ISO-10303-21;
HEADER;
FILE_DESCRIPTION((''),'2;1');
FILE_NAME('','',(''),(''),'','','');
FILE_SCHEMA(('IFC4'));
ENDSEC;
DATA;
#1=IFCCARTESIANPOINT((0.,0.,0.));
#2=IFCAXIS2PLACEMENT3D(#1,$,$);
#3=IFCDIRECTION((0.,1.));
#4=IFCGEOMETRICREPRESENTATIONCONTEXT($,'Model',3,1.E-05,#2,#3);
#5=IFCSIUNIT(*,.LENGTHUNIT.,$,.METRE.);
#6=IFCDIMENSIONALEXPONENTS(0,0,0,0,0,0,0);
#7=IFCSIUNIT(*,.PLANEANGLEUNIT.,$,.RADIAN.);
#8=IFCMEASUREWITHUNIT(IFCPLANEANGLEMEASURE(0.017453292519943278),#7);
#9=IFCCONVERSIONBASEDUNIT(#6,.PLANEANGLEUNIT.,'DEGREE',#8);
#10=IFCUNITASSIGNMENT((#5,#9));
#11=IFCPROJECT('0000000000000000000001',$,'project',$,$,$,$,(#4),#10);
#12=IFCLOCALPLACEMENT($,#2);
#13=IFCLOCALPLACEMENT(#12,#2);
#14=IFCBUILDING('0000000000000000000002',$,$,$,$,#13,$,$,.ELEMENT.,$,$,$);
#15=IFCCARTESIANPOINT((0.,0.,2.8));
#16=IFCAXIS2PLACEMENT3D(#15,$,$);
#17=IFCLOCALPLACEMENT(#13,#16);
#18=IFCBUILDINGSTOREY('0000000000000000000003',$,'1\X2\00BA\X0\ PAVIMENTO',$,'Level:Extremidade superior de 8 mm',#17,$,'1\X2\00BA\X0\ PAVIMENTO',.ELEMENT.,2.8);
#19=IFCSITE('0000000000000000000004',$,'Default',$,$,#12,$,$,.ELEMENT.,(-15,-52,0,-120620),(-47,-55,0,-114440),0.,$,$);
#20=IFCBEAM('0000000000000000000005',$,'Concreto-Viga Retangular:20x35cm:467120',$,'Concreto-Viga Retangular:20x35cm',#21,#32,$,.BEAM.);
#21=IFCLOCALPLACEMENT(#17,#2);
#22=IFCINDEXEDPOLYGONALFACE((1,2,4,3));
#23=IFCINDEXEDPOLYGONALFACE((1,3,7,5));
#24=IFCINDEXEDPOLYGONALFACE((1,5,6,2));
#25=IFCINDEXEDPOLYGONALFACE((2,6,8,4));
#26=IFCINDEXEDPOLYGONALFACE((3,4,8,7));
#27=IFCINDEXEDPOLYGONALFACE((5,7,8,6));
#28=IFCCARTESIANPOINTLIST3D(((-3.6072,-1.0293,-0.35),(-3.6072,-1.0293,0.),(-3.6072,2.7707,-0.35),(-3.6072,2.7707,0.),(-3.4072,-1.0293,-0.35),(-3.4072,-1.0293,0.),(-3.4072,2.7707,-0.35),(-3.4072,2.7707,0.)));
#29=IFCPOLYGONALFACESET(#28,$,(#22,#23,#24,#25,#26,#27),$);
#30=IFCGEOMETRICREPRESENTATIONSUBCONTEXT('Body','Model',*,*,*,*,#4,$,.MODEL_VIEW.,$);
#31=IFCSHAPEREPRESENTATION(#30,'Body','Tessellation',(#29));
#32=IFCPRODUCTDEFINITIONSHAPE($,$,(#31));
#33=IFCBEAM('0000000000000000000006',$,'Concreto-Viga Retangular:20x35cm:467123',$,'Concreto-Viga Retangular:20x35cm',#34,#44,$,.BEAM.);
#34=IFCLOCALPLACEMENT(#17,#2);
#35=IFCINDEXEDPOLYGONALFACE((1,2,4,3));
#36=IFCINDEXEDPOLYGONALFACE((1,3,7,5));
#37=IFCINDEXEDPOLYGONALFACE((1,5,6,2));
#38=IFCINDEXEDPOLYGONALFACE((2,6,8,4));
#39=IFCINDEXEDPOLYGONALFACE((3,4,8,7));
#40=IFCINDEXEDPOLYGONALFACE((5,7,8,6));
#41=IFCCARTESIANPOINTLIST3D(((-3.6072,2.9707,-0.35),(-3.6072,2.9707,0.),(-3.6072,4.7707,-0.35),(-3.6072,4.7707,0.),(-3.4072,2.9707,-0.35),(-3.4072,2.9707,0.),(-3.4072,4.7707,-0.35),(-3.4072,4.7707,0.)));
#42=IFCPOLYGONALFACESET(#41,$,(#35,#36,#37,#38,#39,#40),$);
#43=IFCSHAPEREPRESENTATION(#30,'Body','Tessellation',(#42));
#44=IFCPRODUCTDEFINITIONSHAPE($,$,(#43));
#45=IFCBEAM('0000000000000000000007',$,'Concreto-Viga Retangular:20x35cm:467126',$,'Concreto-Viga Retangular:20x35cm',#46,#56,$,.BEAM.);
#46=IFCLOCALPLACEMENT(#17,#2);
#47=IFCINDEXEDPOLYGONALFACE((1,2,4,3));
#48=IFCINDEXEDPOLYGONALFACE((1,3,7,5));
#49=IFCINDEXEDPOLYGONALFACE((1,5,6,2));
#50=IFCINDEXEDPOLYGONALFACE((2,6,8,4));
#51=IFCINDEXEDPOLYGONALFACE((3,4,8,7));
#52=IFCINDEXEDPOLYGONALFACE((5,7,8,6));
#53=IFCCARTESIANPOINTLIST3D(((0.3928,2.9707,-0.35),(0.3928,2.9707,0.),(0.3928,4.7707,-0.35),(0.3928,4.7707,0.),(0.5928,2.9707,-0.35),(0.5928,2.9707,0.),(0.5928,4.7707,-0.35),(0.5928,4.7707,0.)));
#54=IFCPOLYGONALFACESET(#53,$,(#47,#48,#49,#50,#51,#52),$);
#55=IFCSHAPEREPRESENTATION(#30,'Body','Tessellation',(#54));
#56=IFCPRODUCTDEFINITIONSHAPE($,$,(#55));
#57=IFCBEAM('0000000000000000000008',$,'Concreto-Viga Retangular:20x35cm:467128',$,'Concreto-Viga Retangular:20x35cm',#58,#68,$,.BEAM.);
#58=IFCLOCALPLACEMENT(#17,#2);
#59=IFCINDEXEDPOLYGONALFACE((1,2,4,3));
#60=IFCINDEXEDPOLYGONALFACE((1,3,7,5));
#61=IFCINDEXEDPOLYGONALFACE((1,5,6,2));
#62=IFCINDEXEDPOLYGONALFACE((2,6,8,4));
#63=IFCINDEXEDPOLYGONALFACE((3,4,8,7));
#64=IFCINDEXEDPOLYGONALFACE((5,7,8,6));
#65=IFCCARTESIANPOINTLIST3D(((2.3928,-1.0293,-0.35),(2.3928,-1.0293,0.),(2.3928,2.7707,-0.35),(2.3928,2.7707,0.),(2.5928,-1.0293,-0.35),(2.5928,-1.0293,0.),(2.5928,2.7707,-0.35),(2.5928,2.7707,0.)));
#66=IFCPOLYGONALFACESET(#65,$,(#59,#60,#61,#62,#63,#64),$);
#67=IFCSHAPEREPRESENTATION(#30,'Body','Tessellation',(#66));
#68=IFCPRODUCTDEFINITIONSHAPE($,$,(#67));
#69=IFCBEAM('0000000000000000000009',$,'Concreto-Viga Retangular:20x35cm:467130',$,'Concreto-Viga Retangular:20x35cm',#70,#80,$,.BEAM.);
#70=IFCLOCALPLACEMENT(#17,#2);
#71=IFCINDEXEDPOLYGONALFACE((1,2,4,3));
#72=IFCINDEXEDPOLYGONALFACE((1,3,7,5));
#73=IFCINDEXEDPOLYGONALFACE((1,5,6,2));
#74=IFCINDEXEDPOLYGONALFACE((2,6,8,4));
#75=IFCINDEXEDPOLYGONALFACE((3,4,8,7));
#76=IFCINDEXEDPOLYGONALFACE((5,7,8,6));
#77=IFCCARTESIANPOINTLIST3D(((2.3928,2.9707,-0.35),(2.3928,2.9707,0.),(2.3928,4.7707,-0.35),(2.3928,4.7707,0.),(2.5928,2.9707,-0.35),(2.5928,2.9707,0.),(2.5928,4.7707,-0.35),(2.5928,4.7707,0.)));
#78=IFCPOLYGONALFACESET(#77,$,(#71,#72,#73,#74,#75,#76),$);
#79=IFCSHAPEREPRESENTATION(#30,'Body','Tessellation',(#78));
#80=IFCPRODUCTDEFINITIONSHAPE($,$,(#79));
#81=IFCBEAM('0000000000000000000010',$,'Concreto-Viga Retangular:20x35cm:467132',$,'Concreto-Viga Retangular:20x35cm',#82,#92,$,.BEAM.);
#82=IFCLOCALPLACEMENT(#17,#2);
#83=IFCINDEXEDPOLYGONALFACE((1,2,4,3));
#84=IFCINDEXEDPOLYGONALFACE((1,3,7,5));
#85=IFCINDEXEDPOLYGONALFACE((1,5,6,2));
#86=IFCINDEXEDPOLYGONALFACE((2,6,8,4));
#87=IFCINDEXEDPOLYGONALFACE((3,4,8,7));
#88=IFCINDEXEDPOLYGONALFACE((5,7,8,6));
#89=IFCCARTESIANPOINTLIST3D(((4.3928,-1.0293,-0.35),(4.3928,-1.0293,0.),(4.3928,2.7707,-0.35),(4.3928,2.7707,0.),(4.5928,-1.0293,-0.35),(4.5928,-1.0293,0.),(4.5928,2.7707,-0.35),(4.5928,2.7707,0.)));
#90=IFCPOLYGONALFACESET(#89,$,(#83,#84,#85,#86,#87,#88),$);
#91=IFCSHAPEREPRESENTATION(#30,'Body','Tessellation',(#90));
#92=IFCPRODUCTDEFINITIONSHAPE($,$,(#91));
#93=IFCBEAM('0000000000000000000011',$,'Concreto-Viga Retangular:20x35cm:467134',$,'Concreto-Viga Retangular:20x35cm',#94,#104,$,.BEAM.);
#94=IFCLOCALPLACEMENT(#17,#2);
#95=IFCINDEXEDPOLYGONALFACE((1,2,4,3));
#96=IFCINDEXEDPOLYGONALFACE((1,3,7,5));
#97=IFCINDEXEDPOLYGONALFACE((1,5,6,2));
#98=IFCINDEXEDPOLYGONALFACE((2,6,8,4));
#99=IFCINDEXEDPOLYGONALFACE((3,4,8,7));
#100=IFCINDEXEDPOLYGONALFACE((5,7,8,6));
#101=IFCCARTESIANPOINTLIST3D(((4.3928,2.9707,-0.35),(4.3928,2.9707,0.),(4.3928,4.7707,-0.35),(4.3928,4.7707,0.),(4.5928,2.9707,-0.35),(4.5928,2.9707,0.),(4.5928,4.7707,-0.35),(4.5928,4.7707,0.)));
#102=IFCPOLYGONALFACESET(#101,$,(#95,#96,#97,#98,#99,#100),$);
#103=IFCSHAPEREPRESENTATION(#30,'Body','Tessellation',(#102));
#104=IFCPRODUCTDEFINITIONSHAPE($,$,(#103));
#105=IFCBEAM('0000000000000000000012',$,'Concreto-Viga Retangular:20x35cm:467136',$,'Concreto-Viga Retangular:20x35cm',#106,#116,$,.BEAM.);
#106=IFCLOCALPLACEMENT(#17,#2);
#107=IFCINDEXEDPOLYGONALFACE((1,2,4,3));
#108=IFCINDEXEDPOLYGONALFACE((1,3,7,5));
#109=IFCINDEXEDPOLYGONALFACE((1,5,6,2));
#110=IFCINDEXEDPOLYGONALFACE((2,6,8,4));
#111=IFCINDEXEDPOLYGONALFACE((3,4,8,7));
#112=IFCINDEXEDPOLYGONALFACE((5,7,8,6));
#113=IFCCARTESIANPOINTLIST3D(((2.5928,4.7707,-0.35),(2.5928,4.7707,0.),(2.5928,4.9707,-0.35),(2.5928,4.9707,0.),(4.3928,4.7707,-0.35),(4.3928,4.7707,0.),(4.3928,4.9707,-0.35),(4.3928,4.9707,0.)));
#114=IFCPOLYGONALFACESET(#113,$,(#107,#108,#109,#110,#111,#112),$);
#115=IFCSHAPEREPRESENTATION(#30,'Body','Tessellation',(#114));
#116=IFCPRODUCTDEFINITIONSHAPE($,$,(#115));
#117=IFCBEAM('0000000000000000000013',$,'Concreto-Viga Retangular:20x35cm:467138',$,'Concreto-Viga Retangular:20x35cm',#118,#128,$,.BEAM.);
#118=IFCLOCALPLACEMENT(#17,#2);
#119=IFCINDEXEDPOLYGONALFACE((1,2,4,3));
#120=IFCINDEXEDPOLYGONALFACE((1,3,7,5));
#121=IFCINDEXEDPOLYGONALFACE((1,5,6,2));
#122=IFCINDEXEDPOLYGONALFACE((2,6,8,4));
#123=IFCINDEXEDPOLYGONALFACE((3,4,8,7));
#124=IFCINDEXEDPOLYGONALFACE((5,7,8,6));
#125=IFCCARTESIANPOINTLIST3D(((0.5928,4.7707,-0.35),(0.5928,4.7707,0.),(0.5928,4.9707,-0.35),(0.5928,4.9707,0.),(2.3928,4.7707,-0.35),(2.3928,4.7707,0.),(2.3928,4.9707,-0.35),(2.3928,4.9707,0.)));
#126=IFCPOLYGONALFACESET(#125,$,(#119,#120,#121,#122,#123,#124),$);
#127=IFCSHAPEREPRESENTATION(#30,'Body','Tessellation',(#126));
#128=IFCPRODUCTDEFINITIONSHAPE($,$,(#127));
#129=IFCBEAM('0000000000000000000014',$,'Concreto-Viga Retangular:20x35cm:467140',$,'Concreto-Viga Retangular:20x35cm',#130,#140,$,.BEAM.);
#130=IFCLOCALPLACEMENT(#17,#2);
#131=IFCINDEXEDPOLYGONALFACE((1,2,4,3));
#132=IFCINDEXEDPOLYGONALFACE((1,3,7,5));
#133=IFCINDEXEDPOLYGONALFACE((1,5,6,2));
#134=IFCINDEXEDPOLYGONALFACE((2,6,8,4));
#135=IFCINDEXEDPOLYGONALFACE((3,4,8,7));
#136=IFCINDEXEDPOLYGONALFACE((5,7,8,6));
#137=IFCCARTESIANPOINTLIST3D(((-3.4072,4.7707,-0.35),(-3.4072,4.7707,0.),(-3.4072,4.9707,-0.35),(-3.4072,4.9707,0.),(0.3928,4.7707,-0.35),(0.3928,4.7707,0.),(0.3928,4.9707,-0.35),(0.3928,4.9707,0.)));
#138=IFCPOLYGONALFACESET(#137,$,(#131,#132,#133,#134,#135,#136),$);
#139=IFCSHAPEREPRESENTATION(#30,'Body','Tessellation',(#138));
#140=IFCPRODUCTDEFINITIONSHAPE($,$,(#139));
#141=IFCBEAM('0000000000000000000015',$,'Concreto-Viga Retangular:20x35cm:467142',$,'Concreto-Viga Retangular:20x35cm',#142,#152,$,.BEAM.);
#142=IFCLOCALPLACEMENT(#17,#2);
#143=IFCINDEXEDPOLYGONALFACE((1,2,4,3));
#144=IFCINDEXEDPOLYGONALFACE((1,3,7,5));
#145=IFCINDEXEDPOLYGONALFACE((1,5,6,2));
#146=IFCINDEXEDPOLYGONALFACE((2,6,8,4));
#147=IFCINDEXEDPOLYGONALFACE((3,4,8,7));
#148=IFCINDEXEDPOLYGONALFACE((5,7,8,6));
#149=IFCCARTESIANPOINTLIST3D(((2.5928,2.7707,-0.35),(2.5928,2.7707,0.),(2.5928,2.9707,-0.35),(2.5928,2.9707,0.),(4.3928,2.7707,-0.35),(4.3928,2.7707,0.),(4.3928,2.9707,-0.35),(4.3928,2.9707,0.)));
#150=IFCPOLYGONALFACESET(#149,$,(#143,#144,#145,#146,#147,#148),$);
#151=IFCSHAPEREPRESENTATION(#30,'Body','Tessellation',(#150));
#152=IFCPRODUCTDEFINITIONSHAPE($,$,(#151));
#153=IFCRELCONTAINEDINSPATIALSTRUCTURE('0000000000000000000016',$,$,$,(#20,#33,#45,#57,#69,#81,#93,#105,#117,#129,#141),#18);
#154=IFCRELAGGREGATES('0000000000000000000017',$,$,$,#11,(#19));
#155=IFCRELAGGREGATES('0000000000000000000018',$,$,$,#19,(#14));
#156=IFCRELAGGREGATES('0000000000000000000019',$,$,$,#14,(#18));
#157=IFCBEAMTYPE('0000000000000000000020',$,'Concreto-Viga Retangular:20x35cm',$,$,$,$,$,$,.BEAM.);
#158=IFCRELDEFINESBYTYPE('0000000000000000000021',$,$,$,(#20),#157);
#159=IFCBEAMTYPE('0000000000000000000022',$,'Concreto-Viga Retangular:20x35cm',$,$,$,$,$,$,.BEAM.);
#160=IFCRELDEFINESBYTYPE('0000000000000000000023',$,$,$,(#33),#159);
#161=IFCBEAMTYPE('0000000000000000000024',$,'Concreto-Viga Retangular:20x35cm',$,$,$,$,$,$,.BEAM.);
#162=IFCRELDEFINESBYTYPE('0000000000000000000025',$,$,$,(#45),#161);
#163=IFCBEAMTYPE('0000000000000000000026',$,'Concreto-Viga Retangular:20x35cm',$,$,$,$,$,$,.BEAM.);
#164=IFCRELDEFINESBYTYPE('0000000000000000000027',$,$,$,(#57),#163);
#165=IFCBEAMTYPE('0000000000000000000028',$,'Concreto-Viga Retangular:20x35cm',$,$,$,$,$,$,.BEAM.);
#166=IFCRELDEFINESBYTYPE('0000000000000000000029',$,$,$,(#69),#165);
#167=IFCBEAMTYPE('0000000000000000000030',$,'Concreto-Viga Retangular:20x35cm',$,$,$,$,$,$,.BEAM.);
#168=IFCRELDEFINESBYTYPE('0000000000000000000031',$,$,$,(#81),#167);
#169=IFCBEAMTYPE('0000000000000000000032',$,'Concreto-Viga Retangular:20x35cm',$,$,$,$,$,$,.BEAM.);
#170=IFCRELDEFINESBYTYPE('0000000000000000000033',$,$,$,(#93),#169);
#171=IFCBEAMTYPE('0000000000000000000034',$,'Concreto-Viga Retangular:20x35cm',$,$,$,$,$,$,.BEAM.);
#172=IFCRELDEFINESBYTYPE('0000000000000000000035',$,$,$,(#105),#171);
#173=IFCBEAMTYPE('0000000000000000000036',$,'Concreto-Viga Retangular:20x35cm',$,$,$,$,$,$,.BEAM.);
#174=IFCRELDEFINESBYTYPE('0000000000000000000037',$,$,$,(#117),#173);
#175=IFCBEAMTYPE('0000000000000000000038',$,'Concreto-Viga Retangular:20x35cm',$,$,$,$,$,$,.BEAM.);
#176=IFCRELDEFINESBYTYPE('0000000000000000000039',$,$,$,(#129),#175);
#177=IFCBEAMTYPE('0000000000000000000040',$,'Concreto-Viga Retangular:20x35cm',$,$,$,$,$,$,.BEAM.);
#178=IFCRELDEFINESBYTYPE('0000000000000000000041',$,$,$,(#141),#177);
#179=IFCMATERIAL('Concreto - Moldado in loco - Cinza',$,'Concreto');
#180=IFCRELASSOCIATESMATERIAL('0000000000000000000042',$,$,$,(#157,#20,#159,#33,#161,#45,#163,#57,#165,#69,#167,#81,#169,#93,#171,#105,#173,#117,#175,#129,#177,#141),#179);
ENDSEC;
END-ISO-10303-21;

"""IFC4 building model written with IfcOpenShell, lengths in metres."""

from ifc_helpers import new_model, entity, si_unit, converted_unit, direction, frame, origin, place, context, subcontext, project, spatial, indexed_curve, outline, extrude, source, transform, mapped, material, type_object, type_shapes, element, save


model = new_model("IFC4")

# Units and contexts
model_context = context("Model", 3, precision=1e-05, world=origin(), true_north=direction((0.0, 1.0)))
body_context = subcontext(model_context, "Body", "Model", "MODEL_VIEW")
ifc_project = project(units=[si_unit("LENGTHUNIT", "METRE"), converted_unit("PLANEANGLEUNIT", "DEGREE", entity("IfcPlaneAngleMeasure", 0.017453292519943278), si_unit("PLANEANGLEUNIT", "RADIAN"), dimensions=[0, 0, 0, 0, 0, 0, 0])], contexts=[model_context])

# Site, building, storey
site_placement = place(None, origin())
site = spatial("IfcSite", under=ifc_project, at=site_placement, Name="Default", CompositionType="ELEMENT", RefLatitude=(-15, -52, 0, -120620), RefLongitude=(-47, -55, 0, -114440), RefElevation=0.0)
building_placement = place(site_placement, origin())
building = spatial("IfcBuilding", under=site, at=building_placement, CompositionType="ELEMENT")
storey_placement = place(building_placement, frame((0.0, 0.0, 2.8)))
storey = spatial("IfcBuildingStorey", under=building, at=storey_placement, Name="1º PAVIMENTO", ObjectType="Level:Extremidade superior de 8 mm", LongName="1º PAVIMENTO", CompositionType="ELEMENT", Elevation=2.8)

# Beams
ifc_material = material(Name="Concreto - Moldado in loco - Cinza", Category="Concreto")
beam_type_1 = type_object("IfcBeamType", Name="Concreto-Viga Retangular:20x35cm", PredefinedType="BEAM", material=ifc_material)
shared_shape_1 = source(origin(), body_context, "Body", "SweptSolid", [
    extrude(outline(indexed_curve([(-0.1, -0.175), (0.1, -0.175), (0.1, 0.175), (-0.1, 0.175), (-0.1, -0.175)], self_intersect=False)), frame((-3.5072, -1.0293, 2.625), z_axis=(0.0, 1.0, 0.0), x_axis=(-1.0, 0.0, 0.0)), (0.0, 0.0, 1.0), 3.8),
])
type_shapes(beam_type_1, [shared_shape_1])
beam_1_placement = place(storey_placement, frame((0.0, 0.0, -2.8)))
element("IfcBeam", 1, at=beam_1_placement, inside=storey, type_object=beam_type_1, material=ifc_material, Name="Concreto-Viga Retangular:20x35cm:467120", ObjectType="Concreto-Viga Retangular:20x35cm", PredefinedType="BEAM", context=body_context, shape_type="MappedRepresentation", body=[
    mapped(shared_shape_1, transform((0.0, 0.0, 0.0), scale=1.0)),
])
beam_type_2 = type_object("IfcBeamType", Name="Concreto-Viga Retangular:20x35cm", PredefinedType="BEAM", material=ifc_material)
shared_shape_2 = source(origin(), body_context, "Body", "SweptSolid", [
    extrude(outline(indexed_curve([(-0.1, -0.175), (0.1, -0.175), (0.1, 0.175), (-0.1, 0.175), (-0.1, -0.175)], self_intersect=False)), frame((-3.5072, 2.9707, 2.625), z_axis=(0.0, 1.0, 0.0), x_axis=(-1.0, 0.0, 0.0)), (0.0, 0.0, 1.0), 1.8),
])
type_shapes(beam_type_2, [shared_shape_2])
beam_2_placement = place(storey_placement, frame((0.0, 0.0, -2.8)))
element("IfcBeam", 2, at=beam_2_placement, inside=storey, type_object=beam_type_2, material=ifc_material, Name="Concreto-Viga Retangular:20x35cm:467123", ObjectType="Concreto-Viga Retangular:20x35cm", PredefinedType="BEAM", context=body_context, shape_type="MappedRepresentation", body=[
    mapped(shared_shape_2, transform((0.0, 0.0, 0.0), scale=1.0)),
])
beam_type_3 = type_object("IfcBeamType", Name="Concreto-Viga Retangular:20x35cm", PredefinedType="BEAM", material=ifc_material)
shared_shape_3 = source(origin(), body_context, "Body", "SweptSolid", [
    extrude(outline(indexed_curve([(-0.1, -0.175), (0.1, -0.175), (0.1, 0.175), (-0.1, 0.175), (-0.1, -0.175)], self_intersect=False)), frame((0.4928, 2.9707, 2.625), z_axis=(0.0, 1.0, 0.0), x_axis=(-1.0, 0.0, 0.0)), (0.0, 0.0, 1.0), 1.8),
])
type_shapes(beam_type_3, [shared_shape_3])
beam_3_placement = place(storey_placement, frame((0.0, 0.0, -2.8)))
element("IfcBeam", 3, at=beam_3_placement, inside=storey, type_object=beam_type_3, material=ifc_material, Name="Concreto-Viga Retangular:20x35cm:467126", ObjectType="Concreto-Viga Retangular:20x35cm", PredefinedType="BEAM", context=body_context, shape_type="MappedRepresentation", body=[
    mapped(shared_shape_3, transform((0.0, 0.0, 0.0), scale=1.0)),
])
beam_type_4 = type_object("IfcBeamType", Name="Concreto-Viga Retangular:20x35cm", PredefinedType="BEAM", material=ifc_material)
shared_shape_4 = source(origin(), body_context, "Body", "SweptSolid", [
    extrude(outline(indexed_curve([(-0.1, -0.175), (0.1, -0.175), (0.1, 0.175), (-0.1, 0.175), (-0.1, -0.175)], self_intersect=False)), frame((2.4928, -1.0293, 2.625), z_axis=(0.0, 1.0, 0.0), x_axis=(-1.0, 0.0, 0.0)), (0.0, 0.0, 1.0), 3.8),
])
type_shapes(beam_type_4, [shared_shape_4])
beam_4_placement = place(storey_placement, frame((0.0, 0.0, -2.8)))
element("IfcBeam", 4, at=beam_4_placement, inside=storey, type_object=beam_type_4, material=ifc_material, Name="Concreto-Viga Retangular:20x35cm:467128", ObjectType="Concreto-Viga Retangular:20x35cm", PredefinedType="BEAM", context=body_context, shape_type="MappedRepresentation", body=[
    mapped(shared_shape_4, transform((0.0, 0.0, 0.0), scale=1.0)),
])
beam_type_5 = type_object("IfcBeamType", Name="Concreto-Viga Retangular:20x35cm", PredefinedType="BEAM", material=ifc_material)
shared_shape_5 = source(origin(), body_context, "Body", "SweptSolid", [
    extrude(outline(indexed_curve([(-0.1, -0.175), (0.1, -0.175), (0.1, 0.175), (-0.1, 0.175), (-0.1, -0.175)], self_intersect=False)), frame((2.4928, 2.9707, 2.625), z_axis=(0.0, 1.0, 0.0), x_axis=(-1.0, 0.0, 0.0)), (0.0, 0.0, 1.0), 1.8),
])
type_shapes(beam_type_5, [shared_shape_5])
beam_5_placement = place(storey_placement, frame((0.0, 0.0, -2.8)))
element("IfcBeam", 5, at=beam_5_placement, inside=storey, type_object=beam_type_5, material=ifc_material, Name="Concreto-Viga Retangular:20x35cm:467130", ObjectType="Concreto-Viga Retangular:20x35cm", PredefinedType="BEAM", context=body_context, shape_type="MappedRepresentation", body=[
    mapped(shared_shape_5, transform((0.0, 0.0, 0.0), scale=1.0)),
])
beam_type_6 = type_object("IfcBeamType", Name="Concreto-Viga Retangular:20x35cm", PredefinedType="BEAM", material=ifc_material)
shared_shape_6 = source(origin(), body_context, "Body", "SweptSolid", [
    extrude(outline(indexed_curve([(-0.1, -0.175), (0.1, -0.175), (0.1, 0.175), (-0.1, 0.175), (-0.1, -0.175)], self_intersect=False)), frame((4.4928, -1.0293, 2.625), z_axis=(0.0, 1.0, 0.0), x_axis=(-1.0, 0.0, 0.0)), (0.0, 0.0, 1.0), 3.8),
])
type_shapes(beam_type_6, [shared_shape_6])
beam_6_placement = place(storey_placement, frame((0.0, 0.0, -2.8)))
element("IfcBeam", 6, at=beam_6_placement, inside=storey, type_object=beam_type_6, material=ifc_material, Name="Concreto-Viga Retangular:20x35cm:467132", ObjectType="Concreto-Viga Retangular:20x35cm", PredefinedType="BEAM", context=body_context, shape_type="MappedRepresentation", body=[
    mapped(shared_shape_6, transform((0.0, 0.0, 0.0), scale=1.0)),
])
beam_type_7 = type_object("IfcBeamType", Name="Concreto-Viga Retangular:20x35cm", PredefinedType="BEAM", material=ifc_material)
shared_shape_7 = source(origin(), body_context, "Body", "SweptSolid", [
    extrude(outline(indexed_curve([(-0.1, -0.175), (0.1, -0.175), (0.1, 0.175), (-0.1, 0.175), (-0.1, -0.175)], self_intersect=False)), frame((4.4928, 2.9707, 2.625), z_axis=(0.0, 1.0, 0.0), x_axis=(-1.0, 0.0, 0.0)), (0.0, 0.0, 1.0), 1.8),
])
type_shapes(beam_type_7, [shared_shape_7])
beam_7_placement = place(storey_placement, frame((0.0, 0.0, -2.8)))
element("IfcBeam", 7, at=beam_7_placement, inside=storey, type_object=beam_type_7, material=ifc_material, Name="Concreto-Viga Retangular:20x35cm:467134", ObjectType="Concreto-Viga Retangular:20x35cm", PredefinedType="BEAM", context=body_context, shape_type="MappedRepresentation", body=[
    mapped(shared_shape_7, transform((0.0, 0.0, 0.0), scale=1.0)),
])
beam_type_8 = type_object("IfcBeamType", Name="Concreto-Viga Retangular:20x35cm", PredefinedType="BEAM", material=ifc_material)
shared_shape_8 = source(origin(), body_context, "Body", "SweptSolid", [
    extrude(outline(indexed_curve([(-0.175, -0.1), (0.175, -0.1), (0.175, 0.1), (-0.175, 0.1), (-0.175, -0.1)], self_intersect=False)), frame((4.3928, 4.8707, 2.625), z_axis=(-1.0, 0.0, 0.0), x_axis=(0.0, 0.0, -1.0)), (0.0, 0.0, 1.0), 1.8),
])
type_shapes(beam_type_8, [shared_shape_8])
beam_8_placement = place(storey_placement, frame((0.0, 0.0, -2.8)))
element("IfcBeam", 8, at=beam_8_placement, inside=storey, type_object=beam_type_8, material=ifc_material, Name="Concreto-Viga Retangular:20x35cm:467136", ObjectType="Concreto-Viga Retangular:20x35cm", PredefinedType="BEAM", context=body_context, shape_type="MappedRepresentation", body=[
    mapped(shared_shape_8, transform((0.0, 0.0, 0.0), scale=1.0)),
])
beam_type_9 = type_object("IfcBeamType", Name="Concreto-Viga Retangular:20x35cm", PredefinedType="BEAM", material=ifc_material)
shared_shape_9 = source(origin(), body_context, "Body", "SweptSolid", [
    extrude(outline(indexed_curve([(-0.175, -0.1), (0.175, -0.1), (0.175, 0.1), (-0.175, 0.1), (-0.175, -0.1)], self_intersect=False)), frame((2.3928, 4.8707, 2.625), z_axis=(-1.0, 0.0, 0.0), x_axis=(0.0, 0.0, -1.0)), (0.0, 0.0, 1.0), 1.8),
])
type_shapes(beam_type_9, [shared_shape_9])
beam_9_placement = place(storey_placement, frame((0.0, 0.0, -2.8)))
element("IfcBeam", 9, at=beam_9_placement, inside=storey, type_object=beam_type_9, material=ifc_material, Name="Concreto-Viga Retangular:20x35cm:467138", ObjectType="Concreto-Viga Retangular:20x35cm", PredefinedType="BEAM", context=body_context, shape_type="MappedRepresentation", body=[
    mapped(shared_shape_9, transform((0.0, 0.0, 0.0), scale=1.0)),
])
beam_type_10 = type_object("IfcBeamType", Name="Concreto-Viga Retangular:20x35cm", PredefinedType="BEAM", material=ifc_material)
shared_shape_10 = source(origin(), body_context, "Body", "SweptSolid", [
    extrude(outline(indexed_curve([(-0.175, -0.1), (0.175, -0.1), (0.175, 0.1), (-0.175, 0.1), (-0.175, -0.1)], self_intersect=False)), frame((0.3928, 4.8707, 2.625), z_axis=(-1.0, 0.0, 0.0), x_axis=(0.0, 0.0, -1.0)), (0.0, 0.0, 1.0), 3.8),
])
type_shapes(beam_type_10, [shared_shape_10])
beam_10_placement = place(storey_placement, frame((0.0, 0.0, -2.8)))
element("IfcBeam", 10, at=beam_10_placement, inside=storey, type_object=beam_type_10, material=ifc_material, Name="Concreto-Viga Retangular:20x35cm:467140", ObjectType="Concreto-Viga Retangular:20x35cm", PredefinedType="BEAM", context=body_context, shape_type="MappedRepresentation", body=[
    mapped(shared_shape_10, transform((0.0, 0.0, 0.0), scale=1.0)),
])
beam_type_11 = type_object("IfcBeamType", Name="Concreto-Viga Retangular:20x35cm", PredefinedType="BEAM", material=ifc_material)
shared_shape_11 = source(origin(), body_context, "Body", "SweptSolid", [
    extrude(outline(indexed_curve([(-0.175, -0.1), (0.175, -0.1), (0.175, 0.1), (-0.175, 0.1), (-0.175, -0.1)], self_intersect=False)), frame((4.3928, 2.8707, 2.625), z_axis=(-1.0, 0.0, 0.0), x_axis=(0.0, 0.0, -1.0)), (0.0, 0.0, 1.0), 1.8),
])
type_shapes(beam_type_11, [shared_shape_11])
beam_11_placement = place(storey_placement, frame((0.0, 0.0, -2.8)))
element("IfcBeam", 11, at=beam_11_placement, inside=storey, type_object=beam_type_11, material=ifc_material, Name="Concreto-Viga Retangular:20x35cm:467142", ObjectType="Concreto-Viga Retangular:20x35cm", PredefinedType="BEAM", context=body_context, shape_type="MappedRepresentation", body=[
    mapped(shared_shape_11, transform((0.0, 0.0, 0.0), scale=1.0)),
])

save(model, "model.ifc")
